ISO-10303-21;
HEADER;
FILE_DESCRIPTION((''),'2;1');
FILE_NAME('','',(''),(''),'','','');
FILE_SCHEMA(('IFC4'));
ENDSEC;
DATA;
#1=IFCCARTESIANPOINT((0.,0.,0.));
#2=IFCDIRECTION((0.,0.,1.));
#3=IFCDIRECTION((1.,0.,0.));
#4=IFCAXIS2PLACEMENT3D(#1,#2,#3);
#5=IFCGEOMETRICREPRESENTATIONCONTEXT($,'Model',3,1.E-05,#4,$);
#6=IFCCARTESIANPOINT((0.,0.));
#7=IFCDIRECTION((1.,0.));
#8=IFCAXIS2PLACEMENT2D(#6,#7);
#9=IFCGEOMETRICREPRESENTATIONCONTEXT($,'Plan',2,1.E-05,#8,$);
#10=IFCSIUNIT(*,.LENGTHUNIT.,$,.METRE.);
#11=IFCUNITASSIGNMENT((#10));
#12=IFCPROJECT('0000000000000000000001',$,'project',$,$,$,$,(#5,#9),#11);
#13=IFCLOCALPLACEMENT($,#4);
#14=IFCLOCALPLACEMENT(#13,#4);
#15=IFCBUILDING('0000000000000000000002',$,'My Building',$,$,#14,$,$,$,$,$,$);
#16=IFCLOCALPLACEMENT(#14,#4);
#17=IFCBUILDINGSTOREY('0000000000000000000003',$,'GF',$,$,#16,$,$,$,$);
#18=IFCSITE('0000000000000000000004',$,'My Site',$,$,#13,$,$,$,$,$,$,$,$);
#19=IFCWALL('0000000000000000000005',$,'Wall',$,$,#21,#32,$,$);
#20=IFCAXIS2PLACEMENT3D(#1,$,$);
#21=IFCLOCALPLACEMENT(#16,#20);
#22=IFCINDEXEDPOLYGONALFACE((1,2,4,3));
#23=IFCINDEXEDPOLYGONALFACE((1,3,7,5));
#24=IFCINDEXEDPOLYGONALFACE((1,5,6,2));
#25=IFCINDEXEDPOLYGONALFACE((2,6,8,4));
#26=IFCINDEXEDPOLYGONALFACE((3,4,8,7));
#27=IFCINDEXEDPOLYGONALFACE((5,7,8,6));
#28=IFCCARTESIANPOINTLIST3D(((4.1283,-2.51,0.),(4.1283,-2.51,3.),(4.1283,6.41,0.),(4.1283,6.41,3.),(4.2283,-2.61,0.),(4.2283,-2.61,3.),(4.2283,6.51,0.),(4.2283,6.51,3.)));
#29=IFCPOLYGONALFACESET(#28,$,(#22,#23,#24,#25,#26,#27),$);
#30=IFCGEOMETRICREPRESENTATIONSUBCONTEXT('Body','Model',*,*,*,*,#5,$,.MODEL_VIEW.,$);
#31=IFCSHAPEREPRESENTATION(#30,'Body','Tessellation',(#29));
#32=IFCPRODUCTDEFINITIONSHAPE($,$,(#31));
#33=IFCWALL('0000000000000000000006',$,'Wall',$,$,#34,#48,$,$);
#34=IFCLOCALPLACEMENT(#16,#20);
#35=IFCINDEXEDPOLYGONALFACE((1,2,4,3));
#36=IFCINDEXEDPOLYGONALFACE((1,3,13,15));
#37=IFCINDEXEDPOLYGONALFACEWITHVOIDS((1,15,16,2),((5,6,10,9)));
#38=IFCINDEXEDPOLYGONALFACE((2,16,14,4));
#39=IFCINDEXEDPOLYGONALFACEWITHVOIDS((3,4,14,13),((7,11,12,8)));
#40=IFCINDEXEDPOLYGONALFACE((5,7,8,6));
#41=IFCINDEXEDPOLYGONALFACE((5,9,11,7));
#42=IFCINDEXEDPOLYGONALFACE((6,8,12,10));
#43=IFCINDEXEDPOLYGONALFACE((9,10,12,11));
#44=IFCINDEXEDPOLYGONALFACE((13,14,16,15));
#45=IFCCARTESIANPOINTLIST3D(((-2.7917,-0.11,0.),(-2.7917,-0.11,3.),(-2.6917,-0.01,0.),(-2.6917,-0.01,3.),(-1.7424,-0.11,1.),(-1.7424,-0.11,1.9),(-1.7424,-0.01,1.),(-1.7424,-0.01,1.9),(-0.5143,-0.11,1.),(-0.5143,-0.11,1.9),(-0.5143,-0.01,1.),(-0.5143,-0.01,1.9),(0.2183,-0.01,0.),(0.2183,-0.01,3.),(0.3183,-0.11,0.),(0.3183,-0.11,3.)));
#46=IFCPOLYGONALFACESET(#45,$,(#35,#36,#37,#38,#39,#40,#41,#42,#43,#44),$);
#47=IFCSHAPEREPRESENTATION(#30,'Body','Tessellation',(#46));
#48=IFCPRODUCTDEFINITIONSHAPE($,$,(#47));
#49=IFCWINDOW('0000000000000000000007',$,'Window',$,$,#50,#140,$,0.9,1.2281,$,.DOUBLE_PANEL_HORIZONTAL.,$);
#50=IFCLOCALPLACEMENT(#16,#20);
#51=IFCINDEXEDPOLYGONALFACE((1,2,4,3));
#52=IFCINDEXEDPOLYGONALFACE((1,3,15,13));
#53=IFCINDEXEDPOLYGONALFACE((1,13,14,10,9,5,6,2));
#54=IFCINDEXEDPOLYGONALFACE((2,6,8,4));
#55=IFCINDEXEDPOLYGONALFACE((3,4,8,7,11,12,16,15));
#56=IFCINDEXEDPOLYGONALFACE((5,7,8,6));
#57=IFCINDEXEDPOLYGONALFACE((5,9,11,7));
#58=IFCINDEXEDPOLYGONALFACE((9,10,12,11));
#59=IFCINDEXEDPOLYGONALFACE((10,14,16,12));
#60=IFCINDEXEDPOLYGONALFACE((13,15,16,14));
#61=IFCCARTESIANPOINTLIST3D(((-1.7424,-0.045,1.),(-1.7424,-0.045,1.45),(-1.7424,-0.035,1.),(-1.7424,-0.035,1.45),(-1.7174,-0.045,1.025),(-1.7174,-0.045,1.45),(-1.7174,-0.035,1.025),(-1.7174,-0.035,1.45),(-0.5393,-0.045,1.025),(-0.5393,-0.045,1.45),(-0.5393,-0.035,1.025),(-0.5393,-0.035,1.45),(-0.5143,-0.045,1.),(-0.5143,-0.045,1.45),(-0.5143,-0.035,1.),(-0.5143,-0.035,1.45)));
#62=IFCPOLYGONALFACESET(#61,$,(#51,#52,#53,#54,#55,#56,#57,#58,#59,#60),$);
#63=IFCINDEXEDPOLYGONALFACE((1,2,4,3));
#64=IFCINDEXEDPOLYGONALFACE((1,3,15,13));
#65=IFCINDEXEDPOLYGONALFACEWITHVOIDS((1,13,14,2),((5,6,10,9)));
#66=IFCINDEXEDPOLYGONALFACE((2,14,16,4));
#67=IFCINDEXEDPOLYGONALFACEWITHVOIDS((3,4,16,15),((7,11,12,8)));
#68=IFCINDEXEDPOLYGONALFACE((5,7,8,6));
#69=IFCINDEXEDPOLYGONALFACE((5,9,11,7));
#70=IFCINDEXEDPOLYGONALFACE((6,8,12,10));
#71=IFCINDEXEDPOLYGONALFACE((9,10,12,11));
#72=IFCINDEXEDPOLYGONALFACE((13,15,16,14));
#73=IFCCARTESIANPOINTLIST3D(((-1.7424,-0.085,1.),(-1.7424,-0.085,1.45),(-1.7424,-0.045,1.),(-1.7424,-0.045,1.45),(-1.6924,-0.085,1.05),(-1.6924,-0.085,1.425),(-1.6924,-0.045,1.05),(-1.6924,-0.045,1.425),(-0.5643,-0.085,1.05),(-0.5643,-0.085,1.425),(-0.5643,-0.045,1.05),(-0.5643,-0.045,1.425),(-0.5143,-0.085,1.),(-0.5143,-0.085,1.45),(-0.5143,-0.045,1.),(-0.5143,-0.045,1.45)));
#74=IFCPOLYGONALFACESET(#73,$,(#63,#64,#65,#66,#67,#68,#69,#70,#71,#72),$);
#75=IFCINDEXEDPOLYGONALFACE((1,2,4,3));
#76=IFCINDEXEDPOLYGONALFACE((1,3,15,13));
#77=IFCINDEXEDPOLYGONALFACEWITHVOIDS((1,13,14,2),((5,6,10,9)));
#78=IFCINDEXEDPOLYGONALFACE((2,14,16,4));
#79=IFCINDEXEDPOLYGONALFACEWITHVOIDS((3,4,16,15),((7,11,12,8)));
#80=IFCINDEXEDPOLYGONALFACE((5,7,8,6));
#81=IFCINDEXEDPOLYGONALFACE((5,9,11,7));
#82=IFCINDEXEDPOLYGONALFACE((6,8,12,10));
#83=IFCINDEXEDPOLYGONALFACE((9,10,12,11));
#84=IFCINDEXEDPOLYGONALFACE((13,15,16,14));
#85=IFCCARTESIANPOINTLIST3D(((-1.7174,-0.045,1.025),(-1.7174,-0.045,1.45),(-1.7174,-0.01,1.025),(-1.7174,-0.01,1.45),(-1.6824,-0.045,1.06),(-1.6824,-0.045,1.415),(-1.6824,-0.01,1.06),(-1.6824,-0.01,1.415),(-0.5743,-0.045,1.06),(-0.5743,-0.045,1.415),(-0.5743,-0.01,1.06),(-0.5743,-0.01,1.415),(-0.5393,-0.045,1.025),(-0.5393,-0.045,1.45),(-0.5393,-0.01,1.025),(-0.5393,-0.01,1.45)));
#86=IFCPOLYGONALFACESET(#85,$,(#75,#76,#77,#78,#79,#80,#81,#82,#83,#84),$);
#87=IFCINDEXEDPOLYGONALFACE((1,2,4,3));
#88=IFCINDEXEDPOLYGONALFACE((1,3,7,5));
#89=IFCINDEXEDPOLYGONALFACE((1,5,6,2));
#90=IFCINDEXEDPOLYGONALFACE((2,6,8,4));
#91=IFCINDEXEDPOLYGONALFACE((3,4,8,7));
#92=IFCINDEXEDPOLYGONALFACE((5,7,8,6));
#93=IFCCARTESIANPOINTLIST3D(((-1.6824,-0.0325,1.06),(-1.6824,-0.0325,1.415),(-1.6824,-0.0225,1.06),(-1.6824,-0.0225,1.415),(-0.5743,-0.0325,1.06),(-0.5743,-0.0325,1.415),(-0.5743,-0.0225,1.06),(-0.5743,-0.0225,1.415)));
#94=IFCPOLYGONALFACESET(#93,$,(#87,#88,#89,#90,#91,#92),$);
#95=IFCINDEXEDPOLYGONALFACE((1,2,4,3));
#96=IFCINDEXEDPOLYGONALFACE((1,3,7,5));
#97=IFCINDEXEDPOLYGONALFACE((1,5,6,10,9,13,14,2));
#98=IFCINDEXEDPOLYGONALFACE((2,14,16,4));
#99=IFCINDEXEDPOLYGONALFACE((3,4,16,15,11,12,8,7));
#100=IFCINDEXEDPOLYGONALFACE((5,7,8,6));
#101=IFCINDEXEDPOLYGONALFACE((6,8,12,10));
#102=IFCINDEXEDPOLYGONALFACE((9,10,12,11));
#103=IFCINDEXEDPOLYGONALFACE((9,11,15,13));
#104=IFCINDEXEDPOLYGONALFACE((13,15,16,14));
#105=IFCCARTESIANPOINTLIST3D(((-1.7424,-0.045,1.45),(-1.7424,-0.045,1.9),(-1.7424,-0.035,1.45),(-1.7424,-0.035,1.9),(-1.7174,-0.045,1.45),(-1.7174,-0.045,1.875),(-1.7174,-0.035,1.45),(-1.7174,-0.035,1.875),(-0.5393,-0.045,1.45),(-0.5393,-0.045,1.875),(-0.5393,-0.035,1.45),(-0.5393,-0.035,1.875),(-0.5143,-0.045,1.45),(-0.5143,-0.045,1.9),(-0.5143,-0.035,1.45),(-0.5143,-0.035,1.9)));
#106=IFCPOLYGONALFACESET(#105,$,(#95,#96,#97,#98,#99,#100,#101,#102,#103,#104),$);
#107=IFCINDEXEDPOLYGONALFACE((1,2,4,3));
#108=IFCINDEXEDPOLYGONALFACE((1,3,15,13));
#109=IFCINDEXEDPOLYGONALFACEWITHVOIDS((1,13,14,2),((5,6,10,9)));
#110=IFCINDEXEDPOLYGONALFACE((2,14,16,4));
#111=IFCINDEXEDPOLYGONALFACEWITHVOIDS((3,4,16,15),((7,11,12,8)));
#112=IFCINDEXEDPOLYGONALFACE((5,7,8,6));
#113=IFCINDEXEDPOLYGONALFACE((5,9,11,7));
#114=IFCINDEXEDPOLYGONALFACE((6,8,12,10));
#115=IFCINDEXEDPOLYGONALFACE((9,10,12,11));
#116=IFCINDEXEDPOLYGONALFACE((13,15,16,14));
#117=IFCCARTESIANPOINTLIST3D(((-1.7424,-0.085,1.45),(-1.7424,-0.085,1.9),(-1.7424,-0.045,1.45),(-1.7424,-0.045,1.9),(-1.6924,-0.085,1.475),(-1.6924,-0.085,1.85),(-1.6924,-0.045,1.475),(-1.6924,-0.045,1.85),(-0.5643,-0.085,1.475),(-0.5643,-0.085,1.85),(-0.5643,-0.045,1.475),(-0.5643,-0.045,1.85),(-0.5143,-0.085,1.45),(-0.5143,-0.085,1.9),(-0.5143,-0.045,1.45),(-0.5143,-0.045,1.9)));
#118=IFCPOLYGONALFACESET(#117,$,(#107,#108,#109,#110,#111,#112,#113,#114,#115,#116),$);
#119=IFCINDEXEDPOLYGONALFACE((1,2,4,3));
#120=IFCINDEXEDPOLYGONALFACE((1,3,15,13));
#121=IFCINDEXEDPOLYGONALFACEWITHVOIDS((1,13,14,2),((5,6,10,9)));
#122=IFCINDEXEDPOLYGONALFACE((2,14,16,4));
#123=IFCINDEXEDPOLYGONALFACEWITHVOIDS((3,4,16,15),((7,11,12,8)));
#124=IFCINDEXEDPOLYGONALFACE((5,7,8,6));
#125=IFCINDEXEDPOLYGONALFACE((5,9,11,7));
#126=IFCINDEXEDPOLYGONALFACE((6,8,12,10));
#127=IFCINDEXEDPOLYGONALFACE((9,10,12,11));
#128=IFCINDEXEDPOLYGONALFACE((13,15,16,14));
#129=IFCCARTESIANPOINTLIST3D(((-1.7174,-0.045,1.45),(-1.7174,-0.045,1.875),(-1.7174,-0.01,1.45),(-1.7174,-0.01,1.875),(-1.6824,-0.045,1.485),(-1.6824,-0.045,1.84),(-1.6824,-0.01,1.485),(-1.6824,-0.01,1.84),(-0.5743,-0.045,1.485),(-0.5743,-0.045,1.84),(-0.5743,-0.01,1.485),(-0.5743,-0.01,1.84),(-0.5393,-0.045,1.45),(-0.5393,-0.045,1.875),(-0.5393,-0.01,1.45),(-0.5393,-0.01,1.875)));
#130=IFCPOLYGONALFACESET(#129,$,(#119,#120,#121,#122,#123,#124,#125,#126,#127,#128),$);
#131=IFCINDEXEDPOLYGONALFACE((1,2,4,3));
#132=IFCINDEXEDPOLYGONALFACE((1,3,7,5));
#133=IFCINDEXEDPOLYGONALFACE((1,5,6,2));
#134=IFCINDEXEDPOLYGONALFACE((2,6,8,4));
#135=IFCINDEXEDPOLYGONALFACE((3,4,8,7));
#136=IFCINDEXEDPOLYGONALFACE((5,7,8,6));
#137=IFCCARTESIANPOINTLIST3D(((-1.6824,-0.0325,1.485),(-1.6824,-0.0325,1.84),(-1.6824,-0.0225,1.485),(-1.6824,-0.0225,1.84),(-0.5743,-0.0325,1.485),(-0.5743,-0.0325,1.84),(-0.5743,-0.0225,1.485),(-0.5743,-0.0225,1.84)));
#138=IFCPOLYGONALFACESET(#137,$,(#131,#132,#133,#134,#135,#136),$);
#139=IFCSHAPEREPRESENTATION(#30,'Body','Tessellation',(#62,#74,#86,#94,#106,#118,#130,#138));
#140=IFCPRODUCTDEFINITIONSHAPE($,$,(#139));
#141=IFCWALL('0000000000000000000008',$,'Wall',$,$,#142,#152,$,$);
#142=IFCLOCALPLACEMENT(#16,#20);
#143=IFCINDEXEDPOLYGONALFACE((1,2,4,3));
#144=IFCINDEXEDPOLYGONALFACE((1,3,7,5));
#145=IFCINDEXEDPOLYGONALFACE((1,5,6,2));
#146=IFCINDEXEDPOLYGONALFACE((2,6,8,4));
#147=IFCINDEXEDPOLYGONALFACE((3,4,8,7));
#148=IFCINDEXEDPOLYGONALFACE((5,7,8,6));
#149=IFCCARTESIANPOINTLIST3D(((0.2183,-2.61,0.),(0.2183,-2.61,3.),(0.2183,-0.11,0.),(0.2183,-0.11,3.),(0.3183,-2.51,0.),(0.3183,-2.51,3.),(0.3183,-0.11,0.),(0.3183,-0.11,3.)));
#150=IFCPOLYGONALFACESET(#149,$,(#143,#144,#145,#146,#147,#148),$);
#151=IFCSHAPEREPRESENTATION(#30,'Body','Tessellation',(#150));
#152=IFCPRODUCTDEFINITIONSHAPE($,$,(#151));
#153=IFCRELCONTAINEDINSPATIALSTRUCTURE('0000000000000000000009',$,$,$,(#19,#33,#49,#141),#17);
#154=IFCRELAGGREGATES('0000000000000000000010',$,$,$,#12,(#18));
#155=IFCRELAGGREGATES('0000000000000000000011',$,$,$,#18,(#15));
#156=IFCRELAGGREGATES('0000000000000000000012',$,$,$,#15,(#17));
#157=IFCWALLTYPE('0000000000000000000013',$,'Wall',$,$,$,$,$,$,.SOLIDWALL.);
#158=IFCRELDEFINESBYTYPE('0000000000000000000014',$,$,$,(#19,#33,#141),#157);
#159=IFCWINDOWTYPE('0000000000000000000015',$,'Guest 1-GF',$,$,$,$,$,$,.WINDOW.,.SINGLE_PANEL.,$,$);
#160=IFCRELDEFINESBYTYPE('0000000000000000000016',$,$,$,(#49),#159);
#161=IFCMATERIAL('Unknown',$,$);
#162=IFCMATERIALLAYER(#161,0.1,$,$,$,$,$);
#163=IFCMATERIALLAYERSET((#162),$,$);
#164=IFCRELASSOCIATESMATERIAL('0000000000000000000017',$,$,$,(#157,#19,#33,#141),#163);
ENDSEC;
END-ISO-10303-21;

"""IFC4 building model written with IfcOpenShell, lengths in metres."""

from ifc_helpers import new_model, entity, si_unit, frame, origin_with_axes, origin_2d_with_axis, place, context, subcontext, project, spatial, line, indexed_curve, outline, extrude, shape, source, transform, mapped, material, layer, layer_set, layer_usage, type_object, type_shapes, element, fill, save


model = new_model("IFC4")

# Units and contexts
model_context_1 = context("Model", 3, precision=1e-05, world=origin_with_axes())
plan_context = context("Plan", 2, precision=1e-05, world=origin_2d_with_axis())
body_context_1 = subcontext(model_context_1, "Body", "Model", "MODEL_VIEW")
body_context_2 = subcontext(plan_context, "Body", "Plan", "PLAN_VIEW")
ifc_project = project(units=[si_unit("LENGTHUNIT", "METRE")], contexts=[model_context_1, plan_context])

# Site, building, storey
site_placement = place(None, origin_with_axes())
site = spatial("IfcSite", under=ifc_project, at=site_placement, Name="My Site")
building_placement = place(site_placement, origin_with_axes())
building = spatial("IfcBuilding", under=site, at=building_placement, Name="My Building")
storey_placement = place(building_placement, origin_with_axes())
storey = spatial("IfcBuildingStorey", under=building, at=storey_placement, Name="GF")

# Shared definitions
ifc_material_1 = material(Name="Unknown")

# Shared definitions
ifc_layer_1 = layer(ifc_material_1, 0.1)
ifc_layer_set_1 = layer_set([ifc_layer_1])
wall_type = type_object("IfcWallType", Name="Wall", PredefinedType="SOLIDWALL", material=ifc_layer_set_1)

# Wall
ifc_layer_usage_1 = layer_usage(ifc_layer_set_1, "AXIS2", "POSITIVE", 0.0)
wall_1_placement = place(storey_placement, frame((4.2283, -2.61, 0.0), z_axis=(0.0, 0.0, 1.0), x_axis=(0.0, 1.0, 0.0)))
element("IfcWall", 1, at=wall_1_placement, inside=storey, type_object=wall_type, material=ifc_layer_usage_1, Name="Wall", context=body_context_1, shape_type="SweptSolid", body=[
    extrude(outline(indexed_curve([(0.0, 0.0), (0.1, 0.1), (9.02, 0.1), (9.12, 0.0)], segments=[line(1, 2, 3, 4, 1)])), origin_with_axes(), (0.0, 0.0, 1.0), 3.0),
])

# Wall, opening, window
ifc_layer_usage_2 = layer_usage(ifc_layer_set_1, "AXIS2", "POSITIVE", 0.0)
wall_2_placement = place(storey_placement, frame((-2.7917, -0.11, 0.0), z_axis=(0.0, 0.0, 1.0), x_axis=(1.0, 0.0, 0.0)))
wall_2 = element("IfcWall", 2, at=wall_2_placement, inside=storey, type_object=wall_type, material=ifc_layer_usage_2, Name="Wall", context=body_context_1, shape_type="SweptSolid", body=[
    extrude(outline(indexed_curve([(0.0, 0.0), (0.1, 0.1), (3.01, 0.1), (3.11, 0.0)], segments=[line(1, 2, 3, 4, 1)])), origin_with_axes(), (0.0, 0.0, 1.0), 3.0),
])
shared_shape_1 = source(origin_with_axes(), body_context_1, "Body", "SweptSolid", [
    extrude(outline(indexed_curve([(0.0, 0.0), (1.2281, 0.0), (1.2281, 0.9), (0.0, 0.9)], segments=[line(1, 2, 3, 4, 1)])), frame((0.0, -0.6, 0.0), z_axis=(0.0, -1.0, 0.0), x_axis=(1.0, 0.0, 0.0)), (0.0, 0.0, -1.0), 1.2),
])
opening_1_placement = place(wall_2_placement, frame((1.0493, -0.025, 1.0), z_axis=(0.0, 0.0, 1.0), x_axis=(1.0, 0.0, 0.0)))
opening_1 = element("IfcOpeningElement", 3, at=opening_1_placement, cuts=wall_2, PredefinedType="OPENING", context=body_context_1, shape_type="MappedRepresentation", body=[
    mapped(shared_shape_1, transform((0.0, 0.0, 0.0), x_axis=(1.0, 0.0, 0.0), y_axis=(0.0, 1.0, 0.0), z_axis=(0.0, 0.0, 1.0), scale=1.0)),
])
window_type_1 = type_object("IfcWindowType", Name="Guest 1-GF", PartitioningType="SINGLE_PANEL", PredefinedType="WINDOW")
shared_shape_2 = source(origin_with_axes(), body_context_1, "Body", "SweptSolid", [
    extrude(outline(indexed_curve([(1.2281, 0.45), (1.2281, 0.0), (0.0, 0.0), (0.0, 0.45), (0.025, 0.45), (0.025, 0.025), (1.2031, 0.025), (1.2031, 0.45)], segments=[line(1, 2, 3, 4, 5, 6, 7, 8, 1)])), frame((0.0, 0.09, 0.0), z_axis=(0.0, -1.0, 0.0), x_axis=(1.0, 0.0, 0.0)), (0.0, 0.0, -1.0), 0.01),
    extrude(outline(indexed_curve([(0.0, 0.0), (1.2281, 0.0), (1.2281, 0.45), (0.0, 0.45)], segments=[line(1, 2, 3, 4, 1)]), holes=[indexed_curve([(0.05, 0.05), (1.1781, 0.05), (1.1781, 0.425), (0.05, 0.425)], segments=[line(1, 2, 3, 4, 1)])]), frame((0.0, 0.05, 0.0), z_axis=(0.0, -1.0, 0.0), x_axis=(1.0, 0.0, 0.0)), (0.0, 0.0, -1.0), 0.04),
    extrude(outline(indexed_curve([(0.0, 0.0), (1.1781, 0.0), (1.1781, 0.425), (0.0, 0.425)], segments=[line(1, 2, 3, 4, 1)]), holes=[indexed_curve([(0.035, 0.035), (1.1431, 0.035), (1.1431, 0.39), (0.035, 0.39)], segments=[line(1, 2, 3, 4, 1)])]), frame((0.025, 0.09, 0.025), z_axis=(0.0, -1.0, 0.0), x_axis=(1.0, 0.0, 0.0)), (0.0, 0.0, -1.0), 0.035),
    extrude(outline(indexed_curve([(0.035, 0.035), (1.1431, 0.035), (1.1431, 0.39), (0.035, 0.39)], segments=[line(1, 2, 3, 4, 1)])), frame((0.025, 0.1025, 0.025), z_axis=(0.0, -1.0, 0.0), x_axis=(1.0, 0.0, 0.0)), (0.0, 0.0, -1.0), 0.01),
    extrude(outline(indexed_curve([(0.0, 0.0), (0.0, 0.45), (1.2281, 0.45), (1.2281, 0.0), (1.2031, 0.0), (1.2031, 0.425), (0.025, 0.425), (0.025, 0.0)], segments=[line(1, 2, 3, 4, 5, 6, 7, 8, 1)])), frame((0.0, 0.09, 0.45), z_axis=(0.0, -1.0, 0.0), x_axis=(1.0, 0.0, 0.0)), (0.0, 0.0, -1.0), 0.01),
    extrude(outline(indexed_curve([(0.0, 0.0), (1.2281, 0.0), (1.2281, 0.45), (0.0, 0.45)], segments=[line(1, 2, 3, 4, 1)]), holes=[indexed_curve([(0.05, 0.025), (1.1781, 0.025), (1.1781, 0.4), (0.05, 0.4)], segments=[line(1, 2, 3, 4, 1)])]), frame((0.0, 0.05, 0.45), z_axis=(0.0, -1.0, 0.0), x_axis=(1.0, 0.0, 0.0)), (0.0, 0.0, -1.0), 0.04),
    extrude(outline(indexed_curve([(0.0, 0.0), (1.1781, 0.0), (1.1781, 0.425), (0.0, 0.425)], segments=[line(1, 2, 3, 4, 1)]), holes=[indexed_curve([(0.035, 0.035), (1.1431, 0.035), (1.1431, 0.39), (0.035, 0.39)], segments=[line(1, 2, 3, 4, 1)])]), frame((0.025, 0.09, 0.45), z_axis=(0.0, -1.0, 0.0), x_axis=(1.0, 0.0, 0.0)), (0.0, 0.0, -1.0), 0.035),
    extrude(outline(indexed_curve([(0.035, 0.035), (1.1431, 0.035), (1.1431, 0.39), (0.035, 0.39)], segments=[line(1, 2, 3, 4, 1)])), frame((0.025, 0.1025, 0.45), z_axis=(0.0, -1.0, 0.0), x_axis=(1.0, 0.0, 0.0)), (0.0, 0.0, -1.0), 0.01),
])
shared_shape_3 = source(origin_with_axes(), body_context_2, "Body", "Curve2D", [
    entity("IfcIndexedPolyCurve", entity("IfcCartesianPointList2D", [[0.05, 0.05], [1.1781, 0.05]])),
    entity("IfcIndexedPolyCurve", entity("IfcCartesianPointList2D", [[0.0, 0.1], [0.025, 0.1], [0.025, 0.09], [0.05, 0.09], [0.05, 0.05], [0.0, 0.05]]), [entity("IfcLineIndex", [1, 2, 3, 4, 5, 6, 1])]),
    entity("IfcIndexedPolyCurve", entity("IfcCartesianPointList2D", [[1.2281, 0.1], [1.2031, 0.1], [1.2031, 0.09], [1.1781, 0.09], [1.1781, 0.05], [1.2281, 0.05]]), [entity("IfcLineIndex", [1, 2, 3, 4, 5, 6, 1])]),
    entity("IfcIndexedPolyCurve", entity("IfcCartesianPointList2D", [[0.025, 0.09], [0.06, 0.09], [0.06, 0.125], [0.025, 0.125]]), [entity("IfcLineIndex", [1, 2, 3, 4, 1])]),
    entity("IfcIndexedPolyCurve", entity("IfcCartesianPointList2D", [[1.2031, 0.09], [1.1681, 0.09], [1.1681, 0.125], [1.2031, 0.125]]), [entity("IfcLineIndex", [1, 2, 3, 4, 1])]),
    entity("IfcIndexedPolyCurve", entity("IfcCartesianPointList2D", [[0.06, 0.09], [1.1681, 0.09]])),
    entity("IfcIndexedPolyCurve", entity("IfcCartesianPointList2D", [[0.06, 0.125], [1.1681, 0.125]])),
    entity("IfcIndexedPolyCurve", entity("IfcCartesianPointList2D", [[0.06, 0.1075], [1.1681, 0.1075]])),
])
type_shapes(window_type_1, [shared_shape_2, shared_shape_3])
window_1_placement = place(opening_1_placement, origin_with_axes())
window_1 = element("IfcWindow", 4, at=window_1_placement, inside=storey, type_object=window_type_1, Name="Window", OverallHeight=0.9, OverallWidth=1.2281, PartitioningType="DOUBLE_PANEL_HORIZONTAL", shapes=[
    shape(body_context_1, "Body", "MappedRepresentation", [mapped(shared_shape_2, transform((0.0, 0.0, 0.0), x_axis=(1.0, 0.0, 0.0), y_axis=(0.0, 1.0, 0.0), z_axis=(0.0, 0.0, 1.0), scale=1.0))]),
    shape(body_context_2, "Body", "MappedRepresentation", [mapped(shared_shape_3, transform((0.0, 0.0, 0.0), x_axis=(1.0, 0.0, 0.0), y_axis=(0.0, 1.0, 0.0), z_axis=(0.0, 0.0, 1.0), scale=1.0))]),
])
fill(opening_1, window_1)

# Wall
ifc_layer_usage_3 = layer_usage(ifc_layer_set_1, "AXIS2", "POSITIVE", 0.0)
wall_3_placement = place(storey_placement, frame((0.2183, -0.11, 0.0), z_axis=(0.0, 0.0, 1.0), x_axis=(0.0, -1.0, 0.0)))
element("IfcWall", 5, at=wall_3_placement, inside=storey, type_object=wall_type, material=ifc_layer_usage_3, Name="Wall", context=body_context_1, shape_type="SweptSolid", body=[
    extrude(outline(indexed_curve([(0.0, 0.0), (0.0, 0.1), (2.4, 0.1), (2.5, 0.0)], segments=[line(1, 2, 3, 4, 1)])), origin_with_axes(), (0.0, 0.0, 1.0), 3.0),
])

save(model, "model.ifc")
